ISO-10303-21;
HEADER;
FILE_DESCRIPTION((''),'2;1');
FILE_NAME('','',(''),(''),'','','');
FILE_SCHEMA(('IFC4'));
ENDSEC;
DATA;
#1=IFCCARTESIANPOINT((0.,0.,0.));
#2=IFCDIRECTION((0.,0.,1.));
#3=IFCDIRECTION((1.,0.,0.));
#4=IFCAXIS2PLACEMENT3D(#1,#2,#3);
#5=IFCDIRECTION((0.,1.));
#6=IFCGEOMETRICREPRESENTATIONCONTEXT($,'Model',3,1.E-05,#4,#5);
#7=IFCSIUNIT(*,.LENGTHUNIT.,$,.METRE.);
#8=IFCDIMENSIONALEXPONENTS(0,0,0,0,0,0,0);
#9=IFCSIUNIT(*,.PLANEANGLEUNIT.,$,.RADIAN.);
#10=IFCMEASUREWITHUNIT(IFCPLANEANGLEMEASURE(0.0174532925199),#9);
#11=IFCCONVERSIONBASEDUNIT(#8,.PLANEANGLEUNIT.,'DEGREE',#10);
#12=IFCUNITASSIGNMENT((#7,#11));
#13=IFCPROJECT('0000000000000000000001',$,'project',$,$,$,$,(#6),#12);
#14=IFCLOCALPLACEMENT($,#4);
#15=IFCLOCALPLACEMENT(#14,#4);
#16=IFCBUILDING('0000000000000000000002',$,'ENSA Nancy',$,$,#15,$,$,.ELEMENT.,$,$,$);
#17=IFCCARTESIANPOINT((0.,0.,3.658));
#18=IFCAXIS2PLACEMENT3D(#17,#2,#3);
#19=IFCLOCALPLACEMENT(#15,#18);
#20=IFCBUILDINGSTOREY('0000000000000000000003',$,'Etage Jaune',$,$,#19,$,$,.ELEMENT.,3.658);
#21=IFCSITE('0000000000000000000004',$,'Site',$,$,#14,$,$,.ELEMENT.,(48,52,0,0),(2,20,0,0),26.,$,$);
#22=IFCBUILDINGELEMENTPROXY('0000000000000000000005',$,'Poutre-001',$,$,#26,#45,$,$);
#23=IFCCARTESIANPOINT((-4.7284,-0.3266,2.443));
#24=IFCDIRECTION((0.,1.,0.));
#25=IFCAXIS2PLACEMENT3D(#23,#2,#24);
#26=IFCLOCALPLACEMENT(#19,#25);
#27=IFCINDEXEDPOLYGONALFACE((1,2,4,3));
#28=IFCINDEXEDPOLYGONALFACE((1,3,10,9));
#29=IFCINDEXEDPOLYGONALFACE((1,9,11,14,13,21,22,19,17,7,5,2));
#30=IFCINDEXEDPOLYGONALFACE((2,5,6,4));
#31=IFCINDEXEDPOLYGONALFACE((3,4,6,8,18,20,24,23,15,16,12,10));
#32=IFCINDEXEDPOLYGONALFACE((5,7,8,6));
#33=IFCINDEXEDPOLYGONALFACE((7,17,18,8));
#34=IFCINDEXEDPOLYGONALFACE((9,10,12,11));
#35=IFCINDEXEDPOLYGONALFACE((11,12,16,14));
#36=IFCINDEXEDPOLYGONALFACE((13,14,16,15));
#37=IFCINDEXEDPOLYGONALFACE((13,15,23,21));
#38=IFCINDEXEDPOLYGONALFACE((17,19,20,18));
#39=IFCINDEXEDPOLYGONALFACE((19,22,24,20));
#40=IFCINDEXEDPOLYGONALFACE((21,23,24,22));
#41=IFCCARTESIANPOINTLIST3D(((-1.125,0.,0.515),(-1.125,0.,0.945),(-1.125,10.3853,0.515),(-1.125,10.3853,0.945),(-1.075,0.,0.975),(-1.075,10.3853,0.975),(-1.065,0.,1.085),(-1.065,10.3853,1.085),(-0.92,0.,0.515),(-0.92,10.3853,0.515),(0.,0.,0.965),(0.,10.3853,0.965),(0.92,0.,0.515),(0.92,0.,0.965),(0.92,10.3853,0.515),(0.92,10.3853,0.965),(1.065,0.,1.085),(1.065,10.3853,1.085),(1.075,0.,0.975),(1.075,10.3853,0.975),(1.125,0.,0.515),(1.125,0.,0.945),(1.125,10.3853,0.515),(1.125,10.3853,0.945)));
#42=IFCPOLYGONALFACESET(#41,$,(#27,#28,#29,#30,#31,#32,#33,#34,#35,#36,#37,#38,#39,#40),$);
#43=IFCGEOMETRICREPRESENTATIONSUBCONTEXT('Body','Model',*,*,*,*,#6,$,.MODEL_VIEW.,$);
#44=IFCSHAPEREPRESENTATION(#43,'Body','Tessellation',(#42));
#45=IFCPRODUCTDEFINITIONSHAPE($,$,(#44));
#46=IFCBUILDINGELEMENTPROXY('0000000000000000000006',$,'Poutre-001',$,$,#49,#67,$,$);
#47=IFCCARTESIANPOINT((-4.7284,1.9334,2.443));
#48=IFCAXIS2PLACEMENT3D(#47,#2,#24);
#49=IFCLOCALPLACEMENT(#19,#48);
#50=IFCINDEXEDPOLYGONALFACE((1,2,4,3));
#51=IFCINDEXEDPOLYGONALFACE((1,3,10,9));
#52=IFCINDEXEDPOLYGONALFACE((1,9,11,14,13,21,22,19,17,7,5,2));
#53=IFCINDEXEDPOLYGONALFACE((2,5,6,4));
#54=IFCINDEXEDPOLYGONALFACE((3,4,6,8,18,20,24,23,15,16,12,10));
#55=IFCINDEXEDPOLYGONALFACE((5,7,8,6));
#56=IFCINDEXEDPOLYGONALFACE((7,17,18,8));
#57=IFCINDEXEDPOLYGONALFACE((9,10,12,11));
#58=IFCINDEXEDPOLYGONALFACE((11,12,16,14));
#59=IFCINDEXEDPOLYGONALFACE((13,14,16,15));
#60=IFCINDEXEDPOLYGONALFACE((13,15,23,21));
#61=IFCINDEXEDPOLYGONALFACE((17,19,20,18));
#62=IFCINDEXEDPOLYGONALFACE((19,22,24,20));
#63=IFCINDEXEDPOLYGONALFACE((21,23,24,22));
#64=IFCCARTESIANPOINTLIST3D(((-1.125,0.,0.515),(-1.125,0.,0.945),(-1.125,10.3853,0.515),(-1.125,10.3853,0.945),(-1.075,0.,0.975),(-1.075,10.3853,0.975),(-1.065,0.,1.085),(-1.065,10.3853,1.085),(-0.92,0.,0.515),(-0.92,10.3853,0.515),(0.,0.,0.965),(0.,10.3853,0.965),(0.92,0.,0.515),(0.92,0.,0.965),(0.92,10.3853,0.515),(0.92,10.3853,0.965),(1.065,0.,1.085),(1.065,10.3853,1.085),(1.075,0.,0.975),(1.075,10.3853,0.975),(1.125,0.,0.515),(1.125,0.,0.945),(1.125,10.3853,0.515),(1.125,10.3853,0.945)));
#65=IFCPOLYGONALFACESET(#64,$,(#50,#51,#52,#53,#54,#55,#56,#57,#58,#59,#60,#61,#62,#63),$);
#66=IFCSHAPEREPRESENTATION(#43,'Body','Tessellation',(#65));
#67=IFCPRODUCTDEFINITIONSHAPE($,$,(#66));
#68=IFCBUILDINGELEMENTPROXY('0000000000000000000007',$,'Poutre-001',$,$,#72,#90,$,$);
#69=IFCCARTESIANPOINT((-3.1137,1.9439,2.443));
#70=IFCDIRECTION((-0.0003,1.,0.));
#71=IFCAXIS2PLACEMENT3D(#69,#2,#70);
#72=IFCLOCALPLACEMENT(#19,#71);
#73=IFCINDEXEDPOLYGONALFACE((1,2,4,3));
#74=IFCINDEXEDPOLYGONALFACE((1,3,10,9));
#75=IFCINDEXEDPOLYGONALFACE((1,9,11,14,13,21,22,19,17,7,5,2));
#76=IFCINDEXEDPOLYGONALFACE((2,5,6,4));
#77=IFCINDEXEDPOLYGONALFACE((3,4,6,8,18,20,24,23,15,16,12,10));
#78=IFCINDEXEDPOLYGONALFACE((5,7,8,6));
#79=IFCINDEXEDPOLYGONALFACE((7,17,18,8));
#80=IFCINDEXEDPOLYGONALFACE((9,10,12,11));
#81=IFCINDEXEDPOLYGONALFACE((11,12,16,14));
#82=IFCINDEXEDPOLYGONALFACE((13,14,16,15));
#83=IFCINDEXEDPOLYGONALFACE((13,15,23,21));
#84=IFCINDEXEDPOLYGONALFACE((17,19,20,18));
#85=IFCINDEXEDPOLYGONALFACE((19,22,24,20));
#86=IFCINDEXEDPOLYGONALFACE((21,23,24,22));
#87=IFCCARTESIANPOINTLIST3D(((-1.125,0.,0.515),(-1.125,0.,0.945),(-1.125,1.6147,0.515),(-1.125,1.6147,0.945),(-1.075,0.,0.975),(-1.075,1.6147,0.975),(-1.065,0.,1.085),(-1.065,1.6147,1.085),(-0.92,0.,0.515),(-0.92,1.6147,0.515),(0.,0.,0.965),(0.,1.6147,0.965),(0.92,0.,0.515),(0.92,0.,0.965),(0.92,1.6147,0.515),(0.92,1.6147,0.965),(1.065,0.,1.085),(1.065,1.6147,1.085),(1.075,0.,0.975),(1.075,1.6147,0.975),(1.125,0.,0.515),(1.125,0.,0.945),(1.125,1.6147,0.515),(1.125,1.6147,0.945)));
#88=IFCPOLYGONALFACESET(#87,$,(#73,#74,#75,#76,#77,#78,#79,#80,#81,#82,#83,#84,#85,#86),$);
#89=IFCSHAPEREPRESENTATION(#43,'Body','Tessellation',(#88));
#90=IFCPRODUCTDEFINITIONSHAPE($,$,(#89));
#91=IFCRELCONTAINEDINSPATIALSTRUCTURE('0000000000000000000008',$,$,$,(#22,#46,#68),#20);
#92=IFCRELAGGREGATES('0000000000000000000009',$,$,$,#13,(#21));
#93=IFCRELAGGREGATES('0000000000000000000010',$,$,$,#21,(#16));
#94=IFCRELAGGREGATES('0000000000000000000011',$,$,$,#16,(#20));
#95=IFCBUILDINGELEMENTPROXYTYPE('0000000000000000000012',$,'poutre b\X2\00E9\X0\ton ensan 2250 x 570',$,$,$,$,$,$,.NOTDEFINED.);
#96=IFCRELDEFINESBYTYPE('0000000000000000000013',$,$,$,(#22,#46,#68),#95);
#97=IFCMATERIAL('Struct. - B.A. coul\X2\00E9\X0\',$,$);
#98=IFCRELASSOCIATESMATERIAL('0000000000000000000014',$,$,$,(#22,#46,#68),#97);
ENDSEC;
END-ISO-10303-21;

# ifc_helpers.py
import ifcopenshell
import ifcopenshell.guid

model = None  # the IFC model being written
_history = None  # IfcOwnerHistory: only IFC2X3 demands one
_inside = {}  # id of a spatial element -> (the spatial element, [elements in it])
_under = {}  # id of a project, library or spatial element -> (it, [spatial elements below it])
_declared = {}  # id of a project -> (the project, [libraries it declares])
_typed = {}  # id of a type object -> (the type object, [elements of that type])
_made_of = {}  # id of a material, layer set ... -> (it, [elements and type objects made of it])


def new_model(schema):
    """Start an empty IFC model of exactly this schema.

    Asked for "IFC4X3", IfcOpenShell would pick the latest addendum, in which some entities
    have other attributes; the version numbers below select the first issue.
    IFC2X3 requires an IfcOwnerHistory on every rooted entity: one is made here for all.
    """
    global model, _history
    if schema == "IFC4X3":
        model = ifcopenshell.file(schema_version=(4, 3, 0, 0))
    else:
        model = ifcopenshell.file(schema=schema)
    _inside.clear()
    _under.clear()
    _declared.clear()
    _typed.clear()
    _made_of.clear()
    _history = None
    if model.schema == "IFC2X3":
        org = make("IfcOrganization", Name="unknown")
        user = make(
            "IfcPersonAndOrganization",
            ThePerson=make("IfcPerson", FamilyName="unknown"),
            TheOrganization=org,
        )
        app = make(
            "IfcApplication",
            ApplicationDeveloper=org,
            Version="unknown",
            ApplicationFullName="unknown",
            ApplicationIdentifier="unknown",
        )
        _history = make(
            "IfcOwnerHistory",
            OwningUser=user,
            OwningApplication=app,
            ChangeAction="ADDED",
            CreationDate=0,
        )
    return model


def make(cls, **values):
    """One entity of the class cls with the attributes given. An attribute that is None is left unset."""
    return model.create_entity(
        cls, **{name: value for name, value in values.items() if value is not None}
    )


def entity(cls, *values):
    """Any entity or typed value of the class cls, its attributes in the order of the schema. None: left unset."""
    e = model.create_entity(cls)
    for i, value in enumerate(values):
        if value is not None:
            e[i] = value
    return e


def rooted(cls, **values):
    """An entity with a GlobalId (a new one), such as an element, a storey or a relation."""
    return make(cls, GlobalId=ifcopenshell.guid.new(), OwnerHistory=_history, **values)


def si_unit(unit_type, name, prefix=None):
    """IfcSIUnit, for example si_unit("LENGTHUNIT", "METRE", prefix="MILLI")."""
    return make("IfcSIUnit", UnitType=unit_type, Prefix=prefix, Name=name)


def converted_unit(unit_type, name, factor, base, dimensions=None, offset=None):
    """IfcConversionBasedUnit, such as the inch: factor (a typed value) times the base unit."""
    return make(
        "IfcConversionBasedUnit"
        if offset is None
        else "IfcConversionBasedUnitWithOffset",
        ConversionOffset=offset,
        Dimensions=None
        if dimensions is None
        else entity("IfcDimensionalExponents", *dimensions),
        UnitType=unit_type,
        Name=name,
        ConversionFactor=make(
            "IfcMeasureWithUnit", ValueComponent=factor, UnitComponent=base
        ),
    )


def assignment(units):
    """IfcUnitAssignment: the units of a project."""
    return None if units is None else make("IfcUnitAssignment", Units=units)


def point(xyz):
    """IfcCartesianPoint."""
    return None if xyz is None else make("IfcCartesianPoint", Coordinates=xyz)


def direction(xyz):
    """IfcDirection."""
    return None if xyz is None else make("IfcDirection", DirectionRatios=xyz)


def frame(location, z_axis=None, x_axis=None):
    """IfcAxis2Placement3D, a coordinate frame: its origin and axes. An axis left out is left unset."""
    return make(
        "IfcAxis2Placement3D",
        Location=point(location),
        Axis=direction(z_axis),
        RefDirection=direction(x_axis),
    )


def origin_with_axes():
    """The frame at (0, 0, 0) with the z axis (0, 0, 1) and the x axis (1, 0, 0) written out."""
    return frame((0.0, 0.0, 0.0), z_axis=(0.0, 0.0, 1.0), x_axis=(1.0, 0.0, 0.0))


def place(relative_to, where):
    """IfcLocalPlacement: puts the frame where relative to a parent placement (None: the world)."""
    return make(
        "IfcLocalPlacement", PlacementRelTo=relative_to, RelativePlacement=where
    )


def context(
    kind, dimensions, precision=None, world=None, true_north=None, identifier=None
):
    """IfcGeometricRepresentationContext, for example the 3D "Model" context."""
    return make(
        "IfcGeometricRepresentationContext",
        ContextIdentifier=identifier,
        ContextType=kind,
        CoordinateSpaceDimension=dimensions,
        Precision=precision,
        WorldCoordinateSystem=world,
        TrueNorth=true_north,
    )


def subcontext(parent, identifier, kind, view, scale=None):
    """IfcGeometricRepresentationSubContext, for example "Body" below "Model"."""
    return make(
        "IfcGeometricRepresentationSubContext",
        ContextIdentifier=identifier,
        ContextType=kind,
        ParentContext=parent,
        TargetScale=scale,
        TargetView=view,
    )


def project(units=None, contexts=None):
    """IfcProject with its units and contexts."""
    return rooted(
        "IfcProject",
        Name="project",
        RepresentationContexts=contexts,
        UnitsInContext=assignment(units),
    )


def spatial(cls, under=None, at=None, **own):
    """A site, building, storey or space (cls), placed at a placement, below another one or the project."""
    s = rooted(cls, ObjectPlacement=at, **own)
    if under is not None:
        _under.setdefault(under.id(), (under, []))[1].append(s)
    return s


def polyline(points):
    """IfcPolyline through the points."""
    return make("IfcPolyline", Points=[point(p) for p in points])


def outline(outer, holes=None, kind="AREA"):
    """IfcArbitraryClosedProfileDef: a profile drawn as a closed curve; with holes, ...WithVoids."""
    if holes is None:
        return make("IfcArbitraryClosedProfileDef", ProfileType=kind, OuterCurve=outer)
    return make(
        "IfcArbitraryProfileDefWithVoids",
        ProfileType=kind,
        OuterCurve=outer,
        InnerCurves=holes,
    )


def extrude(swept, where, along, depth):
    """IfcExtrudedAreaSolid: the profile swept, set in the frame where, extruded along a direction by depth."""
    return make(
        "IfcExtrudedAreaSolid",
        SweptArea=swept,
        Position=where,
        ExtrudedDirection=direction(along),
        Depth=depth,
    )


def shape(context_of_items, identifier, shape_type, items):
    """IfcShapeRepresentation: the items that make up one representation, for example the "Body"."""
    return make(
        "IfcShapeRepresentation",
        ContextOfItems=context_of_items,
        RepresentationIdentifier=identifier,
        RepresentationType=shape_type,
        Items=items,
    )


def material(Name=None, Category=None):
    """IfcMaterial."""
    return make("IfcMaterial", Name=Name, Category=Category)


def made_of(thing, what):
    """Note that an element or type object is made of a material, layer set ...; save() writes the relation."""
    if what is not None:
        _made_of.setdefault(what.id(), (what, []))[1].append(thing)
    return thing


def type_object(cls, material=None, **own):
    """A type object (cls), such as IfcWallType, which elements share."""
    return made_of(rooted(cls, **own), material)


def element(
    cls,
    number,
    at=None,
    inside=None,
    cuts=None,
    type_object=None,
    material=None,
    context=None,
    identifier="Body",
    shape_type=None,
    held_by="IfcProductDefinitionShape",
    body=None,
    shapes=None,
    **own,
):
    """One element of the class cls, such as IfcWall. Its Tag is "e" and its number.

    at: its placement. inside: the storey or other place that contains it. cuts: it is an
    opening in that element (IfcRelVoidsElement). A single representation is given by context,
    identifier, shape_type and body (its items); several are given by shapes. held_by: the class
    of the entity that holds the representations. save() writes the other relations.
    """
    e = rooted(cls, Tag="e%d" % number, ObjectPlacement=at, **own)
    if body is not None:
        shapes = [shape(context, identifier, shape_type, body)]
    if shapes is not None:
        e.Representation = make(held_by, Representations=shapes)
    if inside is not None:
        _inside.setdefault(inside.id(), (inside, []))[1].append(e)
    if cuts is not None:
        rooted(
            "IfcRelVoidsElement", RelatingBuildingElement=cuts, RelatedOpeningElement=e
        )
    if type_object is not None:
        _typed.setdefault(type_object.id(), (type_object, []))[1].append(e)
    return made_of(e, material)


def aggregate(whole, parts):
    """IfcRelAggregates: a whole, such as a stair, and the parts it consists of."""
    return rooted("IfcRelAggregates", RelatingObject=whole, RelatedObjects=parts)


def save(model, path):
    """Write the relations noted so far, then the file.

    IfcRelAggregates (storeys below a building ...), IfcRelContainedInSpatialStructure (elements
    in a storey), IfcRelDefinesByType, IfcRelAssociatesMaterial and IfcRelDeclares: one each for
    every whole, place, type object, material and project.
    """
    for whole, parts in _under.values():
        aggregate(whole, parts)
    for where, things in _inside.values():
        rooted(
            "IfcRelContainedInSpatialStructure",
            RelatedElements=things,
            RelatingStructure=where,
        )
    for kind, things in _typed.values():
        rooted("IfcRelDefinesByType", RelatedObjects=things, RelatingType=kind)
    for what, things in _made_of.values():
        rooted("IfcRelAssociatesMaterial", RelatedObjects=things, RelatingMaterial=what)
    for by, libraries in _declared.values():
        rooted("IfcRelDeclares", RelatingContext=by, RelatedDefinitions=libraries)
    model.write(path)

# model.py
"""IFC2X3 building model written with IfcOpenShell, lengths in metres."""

from ifc_helpers import new_model, entity, si_unit, converted_unit, direction, frame, origin_with_axes, place, context, subcontext, project, spatial, polyline, outline, extrude, material, type_object, element, save


model = new_model("IFC2X3")

# Units and contexts
model_context = context("Model", 3, precision=1e-05, world=origin_with_axes(), true_north=direction((0.0, 1.0)))
body_context = subcontext(model_context, "Body", "Model", "MODEL_VIEW")
ifc_project = project(units=[si_unit("LENGTHUNIT", "METRE"), converted_unit("PLANEANGLEUNIT", "DEGREE", entity("IfcPlaneAngleMeasure", 0.0174532925199), si_unit("PLANEANGLEUNIT", "RADIAN"), dimensions=[0, 0, 0, 0, 0, 0, 0])], contexts=[model_context])

# Site, building, storey
site_placement = place(None, origin_with_axes())
site = spatial("IfcSite", under=ifc_project, at=site_placement, Name="Site", CompositionType="ELEMENT", RefLatitude=(48, 52, 0, 0), RefLongitude=(2, 20, 0, 0), RefElevation=26.0)
building_placement = place(site_placement, origin_with_axes())
building = spatial("IfcBuilding", under=site, at=building_placement, Name="ENSA Nancy", CompositionType="ELEMENT")
storey_placement = place(building_placement, frame((0.0, 0.0, 3.658), z_axis=(0.0, 0.0, 1.0), x_axis=(1.0, 0.0, 0.0)))
storey = spatial("IfcBuildingStorey", under=building, at=storey_placement, Name="Etage Jaune", CompositionType="ELEMENT", Elevation=3.658)

# Building element proxies
ifc_material_1 = material(Name="Struct. - B.A. coulé")
building_element_proxy_type_1 = type_object("IfcBuildingElementProxyType", Name="poutre béton ensan 2250 x 570", PredefinedType="NOTDEFINED")
for number, where, z_axis, x_axis, name in (
    (1, (-4.7284, -0.3266, 2.443), (0.0, 0.0, 1.0), (0.0, 1.0, 0.0), "Poutre-001"),
    (2, (-4.7284, 1.9334, 2.443), (0.0, 0.0, 1.0), (0.0, 1.0, 0.0), "Poutre-001"),
):
    element("IfcBuildingElementProxy", number, at=place(storey_placement, frame(where, z_axis=z_axis, x_axis=x_axis)), inside=storey, type_object=building_element_proxy_type_1, material=ifc_material_1, Name=name, context=body_context, shape_type="SweptSolid", body=[
        extrude(outline(polyline([(-1.065, 1.085), (-1.075, 0.975), (-1.125, 0.945), (-1.125, 0.515), (-0.92, 0.515), (0.0, 0.965), (0.92, 0.965), (0.92, 0.515), (1.125, 0.515), (1.125, 0.945), (1.075, 0.975), (1.065, 1.085), (-1.065, 1.085)])), frame((0.0, 10.3853, 0.0), z_axis=(0.0, -1.0, 0.0), x_axis=(1.0, 0.0, 0.0)), (0.0, 0.0, 1.0), 10.3853),
    ])
proxy_1_placement = place(storey_placement, frame((-3.1137, 1.9439, 2.443), z_axis=(0.0, 0.0, 1.0), x_axis=(-0.0003, 1.0, 0.0)))
element("IfcBuildingElementProxy", 3, at=proxy_1_placement, inside=storey, type_object=building_element_proxy_type_1, material=ifc_material_1, Name="Poutre-001", context=body_context, shape_type="SweptSolid", body=[
    extrude(outline(polyline([(-1.065, 1.085), (-1.075, 0.975), (-1.125, 0.945), (-1.125, 0.515), (-0.92, 0.515), (0.0, 0.965), (0.92, 0.965), (0.92, 0.515), (1.125, 0.515), (1.125, 0.945), (1.075, 0.975), (1.065, 1.085), (-1.065, 1.085)])), frame((0.0, 1.6147, 0.0), z_axis=(0.0, -1.0, 0.0), x_axis=(1.0, 0.0, 0.0)), (0.0, 0.0, 1.0), 1.6147),
])

save(model, "model.ifc")
